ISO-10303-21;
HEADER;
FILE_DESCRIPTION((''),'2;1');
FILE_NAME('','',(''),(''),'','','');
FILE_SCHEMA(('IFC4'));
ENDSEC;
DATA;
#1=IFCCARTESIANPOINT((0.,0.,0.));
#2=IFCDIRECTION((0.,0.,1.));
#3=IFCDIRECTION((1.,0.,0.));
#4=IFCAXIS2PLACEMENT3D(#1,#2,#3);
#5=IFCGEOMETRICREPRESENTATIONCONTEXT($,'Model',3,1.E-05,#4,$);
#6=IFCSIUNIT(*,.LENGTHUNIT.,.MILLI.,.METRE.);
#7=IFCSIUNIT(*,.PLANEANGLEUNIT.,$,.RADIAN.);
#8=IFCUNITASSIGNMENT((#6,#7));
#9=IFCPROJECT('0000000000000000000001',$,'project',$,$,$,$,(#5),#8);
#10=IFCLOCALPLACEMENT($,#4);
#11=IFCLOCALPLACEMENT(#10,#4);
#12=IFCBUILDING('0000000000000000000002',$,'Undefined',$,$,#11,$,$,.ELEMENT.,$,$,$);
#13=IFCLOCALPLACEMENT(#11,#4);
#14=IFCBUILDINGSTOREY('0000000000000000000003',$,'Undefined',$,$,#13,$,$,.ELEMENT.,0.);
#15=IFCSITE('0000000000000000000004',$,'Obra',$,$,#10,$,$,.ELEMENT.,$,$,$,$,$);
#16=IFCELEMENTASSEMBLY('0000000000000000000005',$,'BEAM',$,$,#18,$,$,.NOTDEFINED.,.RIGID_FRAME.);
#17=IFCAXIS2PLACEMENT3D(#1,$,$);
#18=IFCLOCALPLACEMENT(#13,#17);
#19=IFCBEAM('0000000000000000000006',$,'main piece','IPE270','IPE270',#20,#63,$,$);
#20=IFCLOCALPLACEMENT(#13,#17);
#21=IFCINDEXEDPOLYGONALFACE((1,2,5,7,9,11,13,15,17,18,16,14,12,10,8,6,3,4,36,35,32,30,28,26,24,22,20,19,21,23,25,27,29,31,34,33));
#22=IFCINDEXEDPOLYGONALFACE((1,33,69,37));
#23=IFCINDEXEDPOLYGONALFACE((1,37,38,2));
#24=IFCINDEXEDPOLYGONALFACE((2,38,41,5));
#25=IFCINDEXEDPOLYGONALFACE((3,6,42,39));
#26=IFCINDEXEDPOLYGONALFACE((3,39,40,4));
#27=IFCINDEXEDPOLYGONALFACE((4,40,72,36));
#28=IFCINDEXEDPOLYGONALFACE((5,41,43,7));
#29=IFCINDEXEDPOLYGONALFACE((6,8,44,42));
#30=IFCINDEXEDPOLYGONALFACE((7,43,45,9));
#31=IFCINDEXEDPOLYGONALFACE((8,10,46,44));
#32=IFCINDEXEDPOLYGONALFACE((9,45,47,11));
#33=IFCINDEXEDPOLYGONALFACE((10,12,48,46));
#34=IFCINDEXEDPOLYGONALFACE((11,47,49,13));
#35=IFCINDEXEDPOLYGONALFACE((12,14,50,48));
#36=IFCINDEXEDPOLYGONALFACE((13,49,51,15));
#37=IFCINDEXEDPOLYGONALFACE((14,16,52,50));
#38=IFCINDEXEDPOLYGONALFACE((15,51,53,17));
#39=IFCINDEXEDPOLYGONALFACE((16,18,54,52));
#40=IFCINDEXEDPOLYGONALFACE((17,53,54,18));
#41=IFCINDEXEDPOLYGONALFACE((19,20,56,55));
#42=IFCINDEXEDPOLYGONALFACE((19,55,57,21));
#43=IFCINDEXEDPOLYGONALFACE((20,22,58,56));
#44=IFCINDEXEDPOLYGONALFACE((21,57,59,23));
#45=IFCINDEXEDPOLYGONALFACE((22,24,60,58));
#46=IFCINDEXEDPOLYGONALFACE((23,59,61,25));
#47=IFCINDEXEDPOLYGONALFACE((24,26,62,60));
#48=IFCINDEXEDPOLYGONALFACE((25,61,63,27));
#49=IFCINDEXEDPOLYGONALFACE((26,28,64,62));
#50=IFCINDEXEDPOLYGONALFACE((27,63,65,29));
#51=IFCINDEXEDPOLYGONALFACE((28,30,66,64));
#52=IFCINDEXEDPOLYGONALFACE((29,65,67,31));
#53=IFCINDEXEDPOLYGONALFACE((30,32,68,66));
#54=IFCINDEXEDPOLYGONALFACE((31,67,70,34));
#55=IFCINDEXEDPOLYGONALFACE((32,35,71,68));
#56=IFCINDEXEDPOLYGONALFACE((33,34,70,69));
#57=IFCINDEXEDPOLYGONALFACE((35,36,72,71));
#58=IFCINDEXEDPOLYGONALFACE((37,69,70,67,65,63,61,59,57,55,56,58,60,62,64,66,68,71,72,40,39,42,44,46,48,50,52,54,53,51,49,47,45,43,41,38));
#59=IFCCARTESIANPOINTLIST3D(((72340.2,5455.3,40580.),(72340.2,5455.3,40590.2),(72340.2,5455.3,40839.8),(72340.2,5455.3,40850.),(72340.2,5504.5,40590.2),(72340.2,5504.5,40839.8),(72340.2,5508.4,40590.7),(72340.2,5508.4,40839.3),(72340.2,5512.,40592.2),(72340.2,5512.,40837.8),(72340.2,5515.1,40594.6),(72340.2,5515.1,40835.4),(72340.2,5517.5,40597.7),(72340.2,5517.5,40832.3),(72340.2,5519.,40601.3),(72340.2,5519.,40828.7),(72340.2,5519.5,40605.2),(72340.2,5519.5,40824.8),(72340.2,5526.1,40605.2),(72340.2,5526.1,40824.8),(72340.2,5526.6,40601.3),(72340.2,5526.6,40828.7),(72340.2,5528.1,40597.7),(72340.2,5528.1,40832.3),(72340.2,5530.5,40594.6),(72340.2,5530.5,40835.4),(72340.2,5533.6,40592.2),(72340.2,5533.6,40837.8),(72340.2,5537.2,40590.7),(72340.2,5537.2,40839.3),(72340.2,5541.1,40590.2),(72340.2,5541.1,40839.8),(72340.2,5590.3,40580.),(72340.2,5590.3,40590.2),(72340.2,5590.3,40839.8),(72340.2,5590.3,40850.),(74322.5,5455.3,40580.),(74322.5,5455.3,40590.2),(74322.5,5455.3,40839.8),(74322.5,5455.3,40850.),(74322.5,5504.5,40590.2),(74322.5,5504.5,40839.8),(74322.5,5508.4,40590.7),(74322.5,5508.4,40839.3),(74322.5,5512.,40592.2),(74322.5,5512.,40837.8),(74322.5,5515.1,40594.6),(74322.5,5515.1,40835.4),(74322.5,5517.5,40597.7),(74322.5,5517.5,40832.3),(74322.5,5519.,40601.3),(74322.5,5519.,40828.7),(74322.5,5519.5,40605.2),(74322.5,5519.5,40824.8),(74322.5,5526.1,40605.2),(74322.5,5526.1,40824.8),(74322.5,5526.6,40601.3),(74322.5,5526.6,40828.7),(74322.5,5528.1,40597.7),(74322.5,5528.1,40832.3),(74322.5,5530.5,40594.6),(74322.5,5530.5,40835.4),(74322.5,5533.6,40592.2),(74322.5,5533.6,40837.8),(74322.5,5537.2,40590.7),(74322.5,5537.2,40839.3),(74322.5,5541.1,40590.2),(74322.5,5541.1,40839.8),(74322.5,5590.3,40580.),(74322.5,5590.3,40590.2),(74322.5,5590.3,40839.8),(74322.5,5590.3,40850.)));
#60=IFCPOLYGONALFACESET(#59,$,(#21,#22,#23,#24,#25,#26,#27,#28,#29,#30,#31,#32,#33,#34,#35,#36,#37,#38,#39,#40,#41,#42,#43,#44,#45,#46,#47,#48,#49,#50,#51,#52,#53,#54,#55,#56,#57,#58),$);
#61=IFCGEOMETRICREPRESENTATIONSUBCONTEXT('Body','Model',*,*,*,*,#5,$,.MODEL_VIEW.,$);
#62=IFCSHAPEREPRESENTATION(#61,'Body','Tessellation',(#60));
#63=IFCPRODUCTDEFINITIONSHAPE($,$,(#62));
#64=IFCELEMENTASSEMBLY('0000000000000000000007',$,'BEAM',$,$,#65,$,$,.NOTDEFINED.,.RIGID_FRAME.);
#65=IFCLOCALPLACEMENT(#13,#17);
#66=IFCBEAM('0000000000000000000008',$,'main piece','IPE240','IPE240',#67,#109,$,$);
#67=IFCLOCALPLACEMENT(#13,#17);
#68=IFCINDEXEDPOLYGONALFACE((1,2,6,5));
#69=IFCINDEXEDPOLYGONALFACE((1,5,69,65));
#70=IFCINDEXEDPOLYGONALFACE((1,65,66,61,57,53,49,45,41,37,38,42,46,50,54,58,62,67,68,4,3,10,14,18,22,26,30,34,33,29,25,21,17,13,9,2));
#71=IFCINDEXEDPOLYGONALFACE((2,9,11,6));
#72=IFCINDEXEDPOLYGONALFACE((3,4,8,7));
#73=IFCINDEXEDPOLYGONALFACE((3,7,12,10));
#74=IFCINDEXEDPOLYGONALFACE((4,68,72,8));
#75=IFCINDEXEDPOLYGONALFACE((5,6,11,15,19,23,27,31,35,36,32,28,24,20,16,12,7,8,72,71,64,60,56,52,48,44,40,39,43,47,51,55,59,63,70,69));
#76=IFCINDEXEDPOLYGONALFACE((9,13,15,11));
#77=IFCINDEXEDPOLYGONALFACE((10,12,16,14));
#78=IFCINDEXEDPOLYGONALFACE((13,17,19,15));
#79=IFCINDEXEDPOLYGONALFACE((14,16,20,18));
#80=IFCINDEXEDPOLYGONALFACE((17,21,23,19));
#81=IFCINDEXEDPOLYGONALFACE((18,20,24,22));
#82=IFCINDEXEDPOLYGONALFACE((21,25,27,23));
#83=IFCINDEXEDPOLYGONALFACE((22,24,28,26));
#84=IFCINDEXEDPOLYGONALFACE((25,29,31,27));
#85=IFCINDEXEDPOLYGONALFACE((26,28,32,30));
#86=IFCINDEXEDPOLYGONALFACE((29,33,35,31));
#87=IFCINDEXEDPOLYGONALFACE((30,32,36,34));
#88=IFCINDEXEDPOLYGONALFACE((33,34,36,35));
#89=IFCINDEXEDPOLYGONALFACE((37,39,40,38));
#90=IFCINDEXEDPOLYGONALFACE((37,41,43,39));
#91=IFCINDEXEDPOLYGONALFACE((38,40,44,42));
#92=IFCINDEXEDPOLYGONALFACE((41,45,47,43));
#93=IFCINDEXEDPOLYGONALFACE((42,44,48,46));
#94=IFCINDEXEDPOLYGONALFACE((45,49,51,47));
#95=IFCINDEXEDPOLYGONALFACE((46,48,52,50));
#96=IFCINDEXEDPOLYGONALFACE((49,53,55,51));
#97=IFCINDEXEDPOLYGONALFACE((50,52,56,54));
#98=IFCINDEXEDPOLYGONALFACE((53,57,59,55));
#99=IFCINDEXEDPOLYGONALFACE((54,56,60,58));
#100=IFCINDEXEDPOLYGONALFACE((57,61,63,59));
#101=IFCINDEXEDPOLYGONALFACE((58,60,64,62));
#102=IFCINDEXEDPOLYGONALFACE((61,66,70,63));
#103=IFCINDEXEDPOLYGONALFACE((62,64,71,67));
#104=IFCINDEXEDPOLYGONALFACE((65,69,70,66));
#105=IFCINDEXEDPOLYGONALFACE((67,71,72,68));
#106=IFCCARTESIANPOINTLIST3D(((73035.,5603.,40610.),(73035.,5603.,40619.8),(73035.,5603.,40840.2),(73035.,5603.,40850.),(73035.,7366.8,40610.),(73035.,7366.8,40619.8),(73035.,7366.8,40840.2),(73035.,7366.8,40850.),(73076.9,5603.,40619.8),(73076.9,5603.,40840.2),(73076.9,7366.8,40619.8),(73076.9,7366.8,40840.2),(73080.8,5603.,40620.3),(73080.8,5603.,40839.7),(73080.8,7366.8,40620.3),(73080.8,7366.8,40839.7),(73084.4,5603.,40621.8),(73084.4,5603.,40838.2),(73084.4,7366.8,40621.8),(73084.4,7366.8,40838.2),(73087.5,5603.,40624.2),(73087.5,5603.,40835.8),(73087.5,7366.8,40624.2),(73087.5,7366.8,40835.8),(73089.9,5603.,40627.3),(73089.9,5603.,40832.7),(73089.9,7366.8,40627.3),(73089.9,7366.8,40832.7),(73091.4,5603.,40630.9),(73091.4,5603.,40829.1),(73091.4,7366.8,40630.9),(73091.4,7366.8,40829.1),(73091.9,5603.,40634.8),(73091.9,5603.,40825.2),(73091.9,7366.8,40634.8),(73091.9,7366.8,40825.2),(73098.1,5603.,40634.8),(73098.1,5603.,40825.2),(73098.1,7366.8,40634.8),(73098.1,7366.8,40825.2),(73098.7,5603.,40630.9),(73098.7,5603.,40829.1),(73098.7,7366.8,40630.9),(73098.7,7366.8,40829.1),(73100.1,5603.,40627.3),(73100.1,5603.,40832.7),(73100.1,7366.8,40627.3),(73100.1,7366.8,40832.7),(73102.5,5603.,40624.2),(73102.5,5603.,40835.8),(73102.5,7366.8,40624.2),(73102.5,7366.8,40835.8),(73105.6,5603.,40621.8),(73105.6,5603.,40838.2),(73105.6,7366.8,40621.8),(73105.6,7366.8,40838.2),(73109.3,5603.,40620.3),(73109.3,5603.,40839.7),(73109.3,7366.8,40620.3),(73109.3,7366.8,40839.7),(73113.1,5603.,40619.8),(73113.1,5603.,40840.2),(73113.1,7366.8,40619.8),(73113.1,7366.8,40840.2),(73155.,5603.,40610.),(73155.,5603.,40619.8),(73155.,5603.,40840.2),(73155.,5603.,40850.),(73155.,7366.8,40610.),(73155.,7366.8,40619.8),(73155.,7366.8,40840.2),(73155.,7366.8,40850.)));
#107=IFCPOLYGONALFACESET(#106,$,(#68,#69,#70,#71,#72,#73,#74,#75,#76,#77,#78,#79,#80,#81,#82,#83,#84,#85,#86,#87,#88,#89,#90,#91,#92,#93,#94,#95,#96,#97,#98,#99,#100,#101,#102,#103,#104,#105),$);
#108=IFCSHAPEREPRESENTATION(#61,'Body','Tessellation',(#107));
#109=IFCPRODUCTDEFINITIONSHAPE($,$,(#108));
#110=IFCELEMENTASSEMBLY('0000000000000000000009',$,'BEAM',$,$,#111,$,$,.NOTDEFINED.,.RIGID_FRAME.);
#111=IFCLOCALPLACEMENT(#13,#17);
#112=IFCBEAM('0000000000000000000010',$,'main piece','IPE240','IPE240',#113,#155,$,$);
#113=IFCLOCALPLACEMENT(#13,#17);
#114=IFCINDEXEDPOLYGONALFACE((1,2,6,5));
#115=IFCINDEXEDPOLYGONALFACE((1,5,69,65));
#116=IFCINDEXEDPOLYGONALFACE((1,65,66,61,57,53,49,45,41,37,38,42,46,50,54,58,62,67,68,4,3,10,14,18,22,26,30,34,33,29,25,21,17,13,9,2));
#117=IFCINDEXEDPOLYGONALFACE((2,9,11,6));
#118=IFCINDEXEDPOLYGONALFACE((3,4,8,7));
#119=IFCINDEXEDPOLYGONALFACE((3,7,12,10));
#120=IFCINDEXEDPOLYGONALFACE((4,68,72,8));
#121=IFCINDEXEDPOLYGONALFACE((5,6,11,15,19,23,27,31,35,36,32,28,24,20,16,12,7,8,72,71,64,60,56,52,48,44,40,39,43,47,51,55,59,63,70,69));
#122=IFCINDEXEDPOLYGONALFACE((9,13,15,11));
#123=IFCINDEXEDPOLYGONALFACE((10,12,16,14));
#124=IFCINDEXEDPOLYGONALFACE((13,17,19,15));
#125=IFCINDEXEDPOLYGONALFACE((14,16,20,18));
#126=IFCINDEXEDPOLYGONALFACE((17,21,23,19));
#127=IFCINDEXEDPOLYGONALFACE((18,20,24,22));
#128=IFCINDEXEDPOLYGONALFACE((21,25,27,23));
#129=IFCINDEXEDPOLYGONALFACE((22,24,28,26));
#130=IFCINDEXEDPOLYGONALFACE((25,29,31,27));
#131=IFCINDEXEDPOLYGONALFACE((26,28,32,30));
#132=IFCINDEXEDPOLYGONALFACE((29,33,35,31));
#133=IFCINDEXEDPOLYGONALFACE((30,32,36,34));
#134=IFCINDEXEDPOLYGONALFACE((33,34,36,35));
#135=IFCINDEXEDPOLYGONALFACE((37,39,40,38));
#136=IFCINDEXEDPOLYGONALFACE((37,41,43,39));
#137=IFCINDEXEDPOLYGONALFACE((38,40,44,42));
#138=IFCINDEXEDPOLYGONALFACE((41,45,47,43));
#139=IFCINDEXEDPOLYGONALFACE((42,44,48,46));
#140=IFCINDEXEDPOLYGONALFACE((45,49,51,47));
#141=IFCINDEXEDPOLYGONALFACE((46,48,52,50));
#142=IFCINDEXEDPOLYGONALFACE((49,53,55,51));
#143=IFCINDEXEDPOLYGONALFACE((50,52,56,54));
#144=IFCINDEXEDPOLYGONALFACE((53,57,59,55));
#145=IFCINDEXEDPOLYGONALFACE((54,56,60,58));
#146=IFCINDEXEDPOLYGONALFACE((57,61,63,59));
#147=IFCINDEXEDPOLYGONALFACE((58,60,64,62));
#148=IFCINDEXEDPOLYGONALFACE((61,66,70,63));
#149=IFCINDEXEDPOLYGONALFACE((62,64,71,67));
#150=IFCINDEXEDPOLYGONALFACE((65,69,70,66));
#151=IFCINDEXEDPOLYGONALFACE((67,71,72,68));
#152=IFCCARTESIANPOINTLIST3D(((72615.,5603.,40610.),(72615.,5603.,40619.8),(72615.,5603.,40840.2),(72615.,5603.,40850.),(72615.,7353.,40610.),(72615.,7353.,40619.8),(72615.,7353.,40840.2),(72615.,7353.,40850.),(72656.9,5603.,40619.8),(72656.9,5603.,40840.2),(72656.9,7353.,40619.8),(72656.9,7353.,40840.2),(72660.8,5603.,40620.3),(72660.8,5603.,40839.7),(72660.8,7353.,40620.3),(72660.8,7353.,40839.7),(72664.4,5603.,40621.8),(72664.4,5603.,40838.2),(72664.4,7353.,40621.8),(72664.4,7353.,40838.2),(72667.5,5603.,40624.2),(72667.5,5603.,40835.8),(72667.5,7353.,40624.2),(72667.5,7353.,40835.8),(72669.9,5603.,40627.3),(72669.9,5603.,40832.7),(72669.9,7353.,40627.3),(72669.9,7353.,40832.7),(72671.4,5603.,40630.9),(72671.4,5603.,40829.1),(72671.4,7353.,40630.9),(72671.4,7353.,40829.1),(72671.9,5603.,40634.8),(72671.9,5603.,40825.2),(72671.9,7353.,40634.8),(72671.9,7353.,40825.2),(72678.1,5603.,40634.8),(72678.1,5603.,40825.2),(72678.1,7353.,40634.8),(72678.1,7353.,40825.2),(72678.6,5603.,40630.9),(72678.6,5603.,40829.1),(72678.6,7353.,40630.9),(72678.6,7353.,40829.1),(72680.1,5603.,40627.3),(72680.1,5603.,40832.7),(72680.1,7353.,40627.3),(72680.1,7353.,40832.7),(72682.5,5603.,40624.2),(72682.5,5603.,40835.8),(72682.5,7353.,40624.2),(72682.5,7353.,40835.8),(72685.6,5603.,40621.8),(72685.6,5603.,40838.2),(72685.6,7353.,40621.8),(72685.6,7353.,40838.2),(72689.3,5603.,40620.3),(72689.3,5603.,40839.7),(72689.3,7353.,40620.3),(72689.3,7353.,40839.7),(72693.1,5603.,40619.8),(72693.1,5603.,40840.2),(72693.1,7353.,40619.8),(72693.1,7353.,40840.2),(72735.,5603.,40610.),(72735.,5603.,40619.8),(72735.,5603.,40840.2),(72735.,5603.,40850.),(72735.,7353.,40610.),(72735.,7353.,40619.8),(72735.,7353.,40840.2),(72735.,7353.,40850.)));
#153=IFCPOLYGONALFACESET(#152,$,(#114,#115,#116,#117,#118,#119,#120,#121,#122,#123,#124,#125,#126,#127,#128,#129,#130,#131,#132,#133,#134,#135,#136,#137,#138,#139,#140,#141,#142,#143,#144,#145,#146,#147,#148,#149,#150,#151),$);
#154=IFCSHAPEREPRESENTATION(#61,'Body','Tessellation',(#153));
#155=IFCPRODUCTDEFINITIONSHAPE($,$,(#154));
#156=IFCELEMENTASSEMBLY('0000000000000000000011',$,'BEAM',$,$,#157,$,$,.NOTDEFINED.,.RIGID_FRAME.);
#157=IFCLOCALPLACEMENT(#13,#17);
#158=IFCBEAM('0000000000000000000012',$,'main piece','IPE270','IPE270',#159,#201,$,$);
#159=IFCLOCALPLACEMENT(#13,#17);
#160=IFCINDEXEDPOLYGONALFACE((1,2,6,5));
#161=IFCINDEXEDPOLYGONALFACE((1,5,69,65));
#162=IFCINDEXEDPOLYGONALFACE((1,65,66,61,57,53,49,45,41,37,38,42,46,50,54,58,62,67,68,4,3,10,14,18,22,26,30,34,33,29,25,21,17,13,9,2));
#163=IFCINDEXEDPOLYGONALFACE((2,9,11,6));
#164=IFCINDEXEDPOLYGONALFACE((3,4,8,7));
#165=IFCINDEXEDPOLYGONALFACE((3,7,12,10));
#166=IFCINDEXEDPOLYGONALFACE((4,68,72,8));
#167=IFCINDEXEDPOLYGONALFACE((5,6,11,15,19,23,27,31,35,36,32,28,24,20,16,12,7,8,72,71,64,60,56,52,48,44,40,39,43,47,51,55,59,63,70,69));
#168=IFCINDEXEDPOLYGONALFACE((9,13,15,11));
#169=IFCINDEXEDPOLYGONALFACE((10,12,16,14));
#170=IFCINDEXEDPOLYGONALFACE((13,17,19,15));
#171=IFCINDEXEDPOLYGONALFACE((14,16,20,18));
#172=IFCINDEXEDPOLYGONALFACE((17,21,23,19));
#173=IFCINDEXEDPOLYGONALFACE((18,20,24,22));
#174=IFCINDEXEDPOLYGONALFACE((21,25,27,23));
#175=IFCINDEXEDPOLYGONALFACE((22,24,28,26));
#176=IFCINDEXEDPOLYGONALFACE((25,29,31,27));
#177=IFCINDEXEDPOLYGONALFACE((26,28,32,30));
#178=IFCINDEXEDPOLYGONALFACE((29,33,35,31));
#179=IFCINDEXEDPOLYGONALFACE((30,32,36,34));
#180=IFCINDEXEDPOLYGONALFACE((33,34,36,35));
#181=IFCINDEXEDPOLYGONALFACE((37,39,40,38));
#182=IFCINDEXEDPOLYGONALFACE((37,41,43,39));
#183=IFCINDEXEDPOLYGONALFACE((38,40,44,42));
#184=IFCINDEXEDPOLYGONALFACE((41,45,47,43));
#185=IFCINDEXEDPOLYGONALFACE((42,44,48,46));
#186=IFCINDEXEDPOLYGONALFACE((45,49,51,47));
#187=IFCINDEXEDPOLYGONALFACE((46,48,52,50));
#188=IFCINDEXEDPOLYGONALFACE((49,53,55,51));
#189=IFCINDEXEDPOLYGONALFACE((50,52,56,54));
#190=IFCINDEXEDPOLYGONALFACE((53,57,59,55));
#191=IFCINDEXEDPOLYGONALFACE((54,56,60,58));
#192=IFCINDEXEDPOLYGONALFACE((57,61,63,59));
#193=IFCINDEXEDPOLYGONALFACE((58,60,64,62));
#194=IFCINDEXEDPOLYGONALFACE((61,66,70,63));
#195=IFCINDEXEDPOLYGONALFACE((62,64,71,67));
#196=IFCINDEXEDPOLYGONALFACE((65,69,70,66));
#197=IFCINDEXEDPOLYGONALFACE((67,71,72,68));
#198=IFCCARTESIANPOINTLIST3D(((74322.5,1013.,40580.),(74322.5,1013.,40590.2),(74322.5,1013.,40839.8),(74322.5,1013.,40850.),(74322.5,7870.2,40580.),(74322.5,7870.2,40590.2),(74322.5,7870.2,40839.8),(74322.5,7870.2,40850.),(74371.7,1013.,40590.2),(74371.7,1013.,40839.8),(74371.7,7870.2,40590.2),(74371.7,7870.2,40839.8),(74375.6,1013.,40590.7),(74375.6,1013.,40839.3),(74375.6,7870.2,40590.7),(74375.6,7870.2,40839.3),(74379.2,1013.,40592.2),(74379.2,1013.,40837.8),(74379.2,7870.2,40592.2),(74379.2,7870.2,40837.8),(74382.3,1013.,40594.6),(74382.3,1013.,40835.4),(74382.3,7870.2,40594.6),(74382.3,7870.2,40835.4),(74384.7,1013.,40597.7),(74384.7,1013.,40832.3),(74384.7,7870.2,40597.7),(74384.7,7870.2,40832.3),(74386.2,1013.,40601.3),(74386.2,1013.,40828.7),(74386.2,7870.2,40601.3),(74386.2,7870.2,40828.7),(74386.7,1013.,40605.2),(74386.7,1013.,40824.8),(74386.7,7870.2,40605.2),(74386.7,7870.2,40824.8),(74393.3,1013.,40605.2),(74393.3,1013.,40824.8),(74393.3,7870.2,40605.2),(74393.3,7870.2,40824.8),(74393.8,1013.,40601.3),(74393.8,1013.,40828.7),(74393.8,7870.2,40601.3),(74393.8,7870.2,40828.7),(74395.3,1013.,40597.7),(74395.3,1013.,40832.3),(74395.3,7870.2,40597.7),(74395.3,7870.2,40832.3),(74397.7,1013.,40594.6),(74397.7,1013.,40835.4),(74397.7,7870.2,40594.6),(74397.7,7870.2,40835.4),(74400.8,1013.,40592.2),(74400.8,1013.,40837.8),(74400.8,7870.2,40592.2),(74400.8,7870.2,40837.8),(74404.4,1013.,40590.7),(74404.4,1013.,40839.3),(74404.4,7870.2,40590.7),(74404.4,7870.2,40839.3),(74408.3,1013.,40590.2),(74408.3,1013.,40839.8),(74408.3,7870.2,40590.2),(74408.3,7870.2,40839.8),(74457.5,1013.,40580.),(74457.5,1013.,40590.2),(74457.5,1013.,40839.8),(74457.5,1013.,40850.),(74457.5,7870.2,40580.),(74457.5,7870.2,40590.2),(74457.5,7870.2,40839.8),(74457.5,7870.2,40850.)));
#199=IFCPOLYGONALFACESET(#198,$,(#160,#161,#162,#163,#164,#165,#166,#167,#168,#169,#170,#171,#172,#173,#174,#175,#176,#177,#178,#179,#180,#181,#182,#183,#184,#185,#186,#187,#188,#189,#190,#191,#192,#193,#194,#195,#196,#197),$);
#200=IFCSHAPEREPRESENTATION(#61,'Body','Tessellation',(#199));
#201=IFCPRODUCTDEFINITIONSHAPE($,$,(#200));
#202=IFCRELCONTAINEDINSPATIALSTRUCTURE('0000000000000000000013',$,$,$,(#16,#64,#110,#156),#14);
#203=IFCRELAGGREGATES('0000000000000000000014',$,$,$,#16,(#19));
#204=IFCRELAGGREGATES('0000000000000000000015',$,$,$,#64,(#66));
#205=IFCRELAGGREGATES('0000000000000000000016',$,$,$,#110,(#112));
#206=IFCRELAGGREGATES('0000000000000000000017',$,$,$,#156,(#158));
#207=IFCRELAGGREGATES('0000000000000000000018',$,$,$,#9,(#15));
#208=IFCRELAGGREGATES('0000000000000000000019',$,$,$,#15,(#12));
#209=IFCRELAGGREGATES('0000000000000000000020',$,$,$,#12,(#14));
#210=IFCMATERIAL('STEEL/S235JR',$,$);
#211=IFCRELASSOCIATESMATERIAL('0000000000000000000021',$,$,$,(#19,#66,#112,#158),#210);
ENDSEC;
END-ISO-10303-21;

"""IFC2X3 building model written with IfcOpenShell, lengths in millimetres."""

from ifc_helpers import new_model, si_unit, frame, origin_with_axes, origin_2d_with_axis, place, context, subcontext, project, spatial, i_section, extrude, material, element, aggregate, save


model = new_model("IFC2X3")

# Units and contexts
model_context = context("Model", 3, precision=1e-05, world=origin_with_axes())
body_context = subcontext(model_context, "Body", "Model", "MODEL_VIEW")
ifc_project = project(units=[si_unit("LENGTHUNIT", "METRE", prefix="MILLI"), si_unit("PLANEANGLEUNIT", "RADIAN")], contexts=[model_context])

# Site, building, storey
site_placement = place(None, origin_with_axes())
site = spatial("IfcSite", under=ifc_project, at=site_placement, Name="Obra", CompositionType="ELEMENT")
building_placement = place(site_placement, origin_with_axes())
building = spatial("IfcBuilding", under=site, at=building_placement, Name="Undefined", CompositionType="ELEMENT")
storey_placement = place(building_placement, origin_with_axes())
storey = spatial("IfcBuildingStorey", under=building, at=storey_placement, Name="Undefined", CompositionType="ELEMENT", Elevation=0.0)

# Element assemblies, beams
ifc_material_1 = material(Name="STEEL/S235JR")
assembly_1_placement = place(storey_placement, origin_with_axes())
assembly_1 = element("IfcElementAssembly", 1, at=assembly_1_placement, inside=storey, Name="BEAM", AssemblyPlace="NOTDEFINED", PredefinedType="RIGID_FRAME")
beam_1_placement = place(assembly_1_placement, frame((72340.2, 5522.8, 40715.0), z_axis=(0.0, 0.0, 1.0), x_axis=(1.0, 0.0, 0.0)))
beam_1 = element("IfcBeam", 2, at=beam_1_placement, material=ifc_material_1, Name="main piece", Description="IPE270", ObjectType="IPE270", context=body_context, shape_type="SweptSolid", body=[
    extrude(i_section(OverallWidth=135.0, OverallDepth=270.0, WebThickness=6.6, FlangeThickness=10.2, FilletRadius=15.0, at=origin_2d_with_axis()), frame((1982.3, 0.0, 0.0), z_axis=(-1.0, 0.0, 0.0), x_axis=(0.0, -1.0, 0.0)), (0.0, 0.0, 1.0), 1982.3),
])
aggregate(assembly_1, [beam_1])
assembly_2_placement = place(storey_placement, origin_with_axes())
assembly_2 = element("IfcElementAssembly", 3, at=assembly_2_placement, inside=storey, Name="BEAM", AssemblyPlace="NOTDEFINED", PredefinedType="RIGID_FRAME")
beam_2_placement = place(assembly_2_placement, frame((73095.0, 7366.8, 40730.0), z_axis=(0.0, 0.0, 1.0), x_axis=(0.0, -1.0, 0.0)))
beam_2 = element("IfcBeam", 4, at=beam_2_placement, material=ifc_material_1, Name="main piece", Description="IPE240", ObjectType="IPE240", context=body_context, shape_type="SweptSolid", body=[
    extrude(i_section(OverallWidth=120.0, OverallDepth=240.0, WebThickness=6.2, FlangeThickness=9.8, FilletRadius=15.0, at=origin_2d_with_axis()), frame((1763.8, 0.0, 0.0), z_axis=(-1.0, 0.0, 0.0), x_axis=(0.0, -1.0, 0.0)), (0.0, 0.0, 1.0), 1763.8),
])
aggregate(assembly_2, [beam_2])
assembly_3_placement = place(storey_placement, origin_with_axes())
assembly_3 = element("IfcElementAssembly", 5, at=assembly_3_placement, inside=storey, Name="BEAM", AssemblyPlace="NOTDEFINED", PredefinedType="RIGID_FRAME")
beam_3_placement = place(assembly_3_placement, frame((72675.0, 5603.0, 40730.0), z_axis=(0.0, 0.0, 1.0), x_axis=(0.0, 1.0, 0.0)))
beam_3 = element("IfcBeam", 6, at=beam_3_placement, material=ifc_material_1, Name="main piece", Description="IPE240", ObjectType="IPE240", context=body_context, shape_type="SweptSolid", body=[
    extrude(i_section(OverallWidth=120.0, OverallDepth=240.0, WebThickness=6.2, FlangeThickness=9.8, FilletRadius=15.0, at=origin_2d_with_axis()), frame((1750.0, 0.0, 0.0), z_axis=(-1.0, 0.0, 0.0), x_axis=(0.0, -1.0, 0.0)), (0.0, 0.0, 1.0), 1750.0),
])
aggregate(assembly_3, [beam_3])
assembly_4_placement = place(storey_placement, origin_with_axes())
assembly_4 = element("IfcElementAssembly", 7, at=assembly_4_placement, inside=storey, Name="BEAM", AssemblyPlace="NOTDEFINED", PredefinedType="RIGID_FRAME")
beam_4_placement = place(assembly_4_placement, frame((74390.0, 1013.0, 40715.0), z_axis=(0.0, 0.0, 1.0), x_axis=(0.0, 1.0, 0.0)))
beam_4 = element("IfcBeam", 8, at=beam_4_placement, material=ifc_material_1, Name="main piece", Description="IPE270", ObjectType="IPE270", context=body_context, shape_type="SweptSolid", body=[
    extrude(i_section(OverallWidth=135.0, OverallDepth=270.0, WebThickness=6.6, FlangeThickness=10.2, FilletRadius=15.0, at=origin_2d_with_axis()), frame((6857.2, 0.0, 0.0), z_axis=(-1.0, 0.0, 0.0), x_axis=(0.0, -1.0, 0.0)), (0.0, 0.0, 1.0), 6857.2),
])
aggregate(assembly_4, [beam_4])

save(model, "model.ifc")
